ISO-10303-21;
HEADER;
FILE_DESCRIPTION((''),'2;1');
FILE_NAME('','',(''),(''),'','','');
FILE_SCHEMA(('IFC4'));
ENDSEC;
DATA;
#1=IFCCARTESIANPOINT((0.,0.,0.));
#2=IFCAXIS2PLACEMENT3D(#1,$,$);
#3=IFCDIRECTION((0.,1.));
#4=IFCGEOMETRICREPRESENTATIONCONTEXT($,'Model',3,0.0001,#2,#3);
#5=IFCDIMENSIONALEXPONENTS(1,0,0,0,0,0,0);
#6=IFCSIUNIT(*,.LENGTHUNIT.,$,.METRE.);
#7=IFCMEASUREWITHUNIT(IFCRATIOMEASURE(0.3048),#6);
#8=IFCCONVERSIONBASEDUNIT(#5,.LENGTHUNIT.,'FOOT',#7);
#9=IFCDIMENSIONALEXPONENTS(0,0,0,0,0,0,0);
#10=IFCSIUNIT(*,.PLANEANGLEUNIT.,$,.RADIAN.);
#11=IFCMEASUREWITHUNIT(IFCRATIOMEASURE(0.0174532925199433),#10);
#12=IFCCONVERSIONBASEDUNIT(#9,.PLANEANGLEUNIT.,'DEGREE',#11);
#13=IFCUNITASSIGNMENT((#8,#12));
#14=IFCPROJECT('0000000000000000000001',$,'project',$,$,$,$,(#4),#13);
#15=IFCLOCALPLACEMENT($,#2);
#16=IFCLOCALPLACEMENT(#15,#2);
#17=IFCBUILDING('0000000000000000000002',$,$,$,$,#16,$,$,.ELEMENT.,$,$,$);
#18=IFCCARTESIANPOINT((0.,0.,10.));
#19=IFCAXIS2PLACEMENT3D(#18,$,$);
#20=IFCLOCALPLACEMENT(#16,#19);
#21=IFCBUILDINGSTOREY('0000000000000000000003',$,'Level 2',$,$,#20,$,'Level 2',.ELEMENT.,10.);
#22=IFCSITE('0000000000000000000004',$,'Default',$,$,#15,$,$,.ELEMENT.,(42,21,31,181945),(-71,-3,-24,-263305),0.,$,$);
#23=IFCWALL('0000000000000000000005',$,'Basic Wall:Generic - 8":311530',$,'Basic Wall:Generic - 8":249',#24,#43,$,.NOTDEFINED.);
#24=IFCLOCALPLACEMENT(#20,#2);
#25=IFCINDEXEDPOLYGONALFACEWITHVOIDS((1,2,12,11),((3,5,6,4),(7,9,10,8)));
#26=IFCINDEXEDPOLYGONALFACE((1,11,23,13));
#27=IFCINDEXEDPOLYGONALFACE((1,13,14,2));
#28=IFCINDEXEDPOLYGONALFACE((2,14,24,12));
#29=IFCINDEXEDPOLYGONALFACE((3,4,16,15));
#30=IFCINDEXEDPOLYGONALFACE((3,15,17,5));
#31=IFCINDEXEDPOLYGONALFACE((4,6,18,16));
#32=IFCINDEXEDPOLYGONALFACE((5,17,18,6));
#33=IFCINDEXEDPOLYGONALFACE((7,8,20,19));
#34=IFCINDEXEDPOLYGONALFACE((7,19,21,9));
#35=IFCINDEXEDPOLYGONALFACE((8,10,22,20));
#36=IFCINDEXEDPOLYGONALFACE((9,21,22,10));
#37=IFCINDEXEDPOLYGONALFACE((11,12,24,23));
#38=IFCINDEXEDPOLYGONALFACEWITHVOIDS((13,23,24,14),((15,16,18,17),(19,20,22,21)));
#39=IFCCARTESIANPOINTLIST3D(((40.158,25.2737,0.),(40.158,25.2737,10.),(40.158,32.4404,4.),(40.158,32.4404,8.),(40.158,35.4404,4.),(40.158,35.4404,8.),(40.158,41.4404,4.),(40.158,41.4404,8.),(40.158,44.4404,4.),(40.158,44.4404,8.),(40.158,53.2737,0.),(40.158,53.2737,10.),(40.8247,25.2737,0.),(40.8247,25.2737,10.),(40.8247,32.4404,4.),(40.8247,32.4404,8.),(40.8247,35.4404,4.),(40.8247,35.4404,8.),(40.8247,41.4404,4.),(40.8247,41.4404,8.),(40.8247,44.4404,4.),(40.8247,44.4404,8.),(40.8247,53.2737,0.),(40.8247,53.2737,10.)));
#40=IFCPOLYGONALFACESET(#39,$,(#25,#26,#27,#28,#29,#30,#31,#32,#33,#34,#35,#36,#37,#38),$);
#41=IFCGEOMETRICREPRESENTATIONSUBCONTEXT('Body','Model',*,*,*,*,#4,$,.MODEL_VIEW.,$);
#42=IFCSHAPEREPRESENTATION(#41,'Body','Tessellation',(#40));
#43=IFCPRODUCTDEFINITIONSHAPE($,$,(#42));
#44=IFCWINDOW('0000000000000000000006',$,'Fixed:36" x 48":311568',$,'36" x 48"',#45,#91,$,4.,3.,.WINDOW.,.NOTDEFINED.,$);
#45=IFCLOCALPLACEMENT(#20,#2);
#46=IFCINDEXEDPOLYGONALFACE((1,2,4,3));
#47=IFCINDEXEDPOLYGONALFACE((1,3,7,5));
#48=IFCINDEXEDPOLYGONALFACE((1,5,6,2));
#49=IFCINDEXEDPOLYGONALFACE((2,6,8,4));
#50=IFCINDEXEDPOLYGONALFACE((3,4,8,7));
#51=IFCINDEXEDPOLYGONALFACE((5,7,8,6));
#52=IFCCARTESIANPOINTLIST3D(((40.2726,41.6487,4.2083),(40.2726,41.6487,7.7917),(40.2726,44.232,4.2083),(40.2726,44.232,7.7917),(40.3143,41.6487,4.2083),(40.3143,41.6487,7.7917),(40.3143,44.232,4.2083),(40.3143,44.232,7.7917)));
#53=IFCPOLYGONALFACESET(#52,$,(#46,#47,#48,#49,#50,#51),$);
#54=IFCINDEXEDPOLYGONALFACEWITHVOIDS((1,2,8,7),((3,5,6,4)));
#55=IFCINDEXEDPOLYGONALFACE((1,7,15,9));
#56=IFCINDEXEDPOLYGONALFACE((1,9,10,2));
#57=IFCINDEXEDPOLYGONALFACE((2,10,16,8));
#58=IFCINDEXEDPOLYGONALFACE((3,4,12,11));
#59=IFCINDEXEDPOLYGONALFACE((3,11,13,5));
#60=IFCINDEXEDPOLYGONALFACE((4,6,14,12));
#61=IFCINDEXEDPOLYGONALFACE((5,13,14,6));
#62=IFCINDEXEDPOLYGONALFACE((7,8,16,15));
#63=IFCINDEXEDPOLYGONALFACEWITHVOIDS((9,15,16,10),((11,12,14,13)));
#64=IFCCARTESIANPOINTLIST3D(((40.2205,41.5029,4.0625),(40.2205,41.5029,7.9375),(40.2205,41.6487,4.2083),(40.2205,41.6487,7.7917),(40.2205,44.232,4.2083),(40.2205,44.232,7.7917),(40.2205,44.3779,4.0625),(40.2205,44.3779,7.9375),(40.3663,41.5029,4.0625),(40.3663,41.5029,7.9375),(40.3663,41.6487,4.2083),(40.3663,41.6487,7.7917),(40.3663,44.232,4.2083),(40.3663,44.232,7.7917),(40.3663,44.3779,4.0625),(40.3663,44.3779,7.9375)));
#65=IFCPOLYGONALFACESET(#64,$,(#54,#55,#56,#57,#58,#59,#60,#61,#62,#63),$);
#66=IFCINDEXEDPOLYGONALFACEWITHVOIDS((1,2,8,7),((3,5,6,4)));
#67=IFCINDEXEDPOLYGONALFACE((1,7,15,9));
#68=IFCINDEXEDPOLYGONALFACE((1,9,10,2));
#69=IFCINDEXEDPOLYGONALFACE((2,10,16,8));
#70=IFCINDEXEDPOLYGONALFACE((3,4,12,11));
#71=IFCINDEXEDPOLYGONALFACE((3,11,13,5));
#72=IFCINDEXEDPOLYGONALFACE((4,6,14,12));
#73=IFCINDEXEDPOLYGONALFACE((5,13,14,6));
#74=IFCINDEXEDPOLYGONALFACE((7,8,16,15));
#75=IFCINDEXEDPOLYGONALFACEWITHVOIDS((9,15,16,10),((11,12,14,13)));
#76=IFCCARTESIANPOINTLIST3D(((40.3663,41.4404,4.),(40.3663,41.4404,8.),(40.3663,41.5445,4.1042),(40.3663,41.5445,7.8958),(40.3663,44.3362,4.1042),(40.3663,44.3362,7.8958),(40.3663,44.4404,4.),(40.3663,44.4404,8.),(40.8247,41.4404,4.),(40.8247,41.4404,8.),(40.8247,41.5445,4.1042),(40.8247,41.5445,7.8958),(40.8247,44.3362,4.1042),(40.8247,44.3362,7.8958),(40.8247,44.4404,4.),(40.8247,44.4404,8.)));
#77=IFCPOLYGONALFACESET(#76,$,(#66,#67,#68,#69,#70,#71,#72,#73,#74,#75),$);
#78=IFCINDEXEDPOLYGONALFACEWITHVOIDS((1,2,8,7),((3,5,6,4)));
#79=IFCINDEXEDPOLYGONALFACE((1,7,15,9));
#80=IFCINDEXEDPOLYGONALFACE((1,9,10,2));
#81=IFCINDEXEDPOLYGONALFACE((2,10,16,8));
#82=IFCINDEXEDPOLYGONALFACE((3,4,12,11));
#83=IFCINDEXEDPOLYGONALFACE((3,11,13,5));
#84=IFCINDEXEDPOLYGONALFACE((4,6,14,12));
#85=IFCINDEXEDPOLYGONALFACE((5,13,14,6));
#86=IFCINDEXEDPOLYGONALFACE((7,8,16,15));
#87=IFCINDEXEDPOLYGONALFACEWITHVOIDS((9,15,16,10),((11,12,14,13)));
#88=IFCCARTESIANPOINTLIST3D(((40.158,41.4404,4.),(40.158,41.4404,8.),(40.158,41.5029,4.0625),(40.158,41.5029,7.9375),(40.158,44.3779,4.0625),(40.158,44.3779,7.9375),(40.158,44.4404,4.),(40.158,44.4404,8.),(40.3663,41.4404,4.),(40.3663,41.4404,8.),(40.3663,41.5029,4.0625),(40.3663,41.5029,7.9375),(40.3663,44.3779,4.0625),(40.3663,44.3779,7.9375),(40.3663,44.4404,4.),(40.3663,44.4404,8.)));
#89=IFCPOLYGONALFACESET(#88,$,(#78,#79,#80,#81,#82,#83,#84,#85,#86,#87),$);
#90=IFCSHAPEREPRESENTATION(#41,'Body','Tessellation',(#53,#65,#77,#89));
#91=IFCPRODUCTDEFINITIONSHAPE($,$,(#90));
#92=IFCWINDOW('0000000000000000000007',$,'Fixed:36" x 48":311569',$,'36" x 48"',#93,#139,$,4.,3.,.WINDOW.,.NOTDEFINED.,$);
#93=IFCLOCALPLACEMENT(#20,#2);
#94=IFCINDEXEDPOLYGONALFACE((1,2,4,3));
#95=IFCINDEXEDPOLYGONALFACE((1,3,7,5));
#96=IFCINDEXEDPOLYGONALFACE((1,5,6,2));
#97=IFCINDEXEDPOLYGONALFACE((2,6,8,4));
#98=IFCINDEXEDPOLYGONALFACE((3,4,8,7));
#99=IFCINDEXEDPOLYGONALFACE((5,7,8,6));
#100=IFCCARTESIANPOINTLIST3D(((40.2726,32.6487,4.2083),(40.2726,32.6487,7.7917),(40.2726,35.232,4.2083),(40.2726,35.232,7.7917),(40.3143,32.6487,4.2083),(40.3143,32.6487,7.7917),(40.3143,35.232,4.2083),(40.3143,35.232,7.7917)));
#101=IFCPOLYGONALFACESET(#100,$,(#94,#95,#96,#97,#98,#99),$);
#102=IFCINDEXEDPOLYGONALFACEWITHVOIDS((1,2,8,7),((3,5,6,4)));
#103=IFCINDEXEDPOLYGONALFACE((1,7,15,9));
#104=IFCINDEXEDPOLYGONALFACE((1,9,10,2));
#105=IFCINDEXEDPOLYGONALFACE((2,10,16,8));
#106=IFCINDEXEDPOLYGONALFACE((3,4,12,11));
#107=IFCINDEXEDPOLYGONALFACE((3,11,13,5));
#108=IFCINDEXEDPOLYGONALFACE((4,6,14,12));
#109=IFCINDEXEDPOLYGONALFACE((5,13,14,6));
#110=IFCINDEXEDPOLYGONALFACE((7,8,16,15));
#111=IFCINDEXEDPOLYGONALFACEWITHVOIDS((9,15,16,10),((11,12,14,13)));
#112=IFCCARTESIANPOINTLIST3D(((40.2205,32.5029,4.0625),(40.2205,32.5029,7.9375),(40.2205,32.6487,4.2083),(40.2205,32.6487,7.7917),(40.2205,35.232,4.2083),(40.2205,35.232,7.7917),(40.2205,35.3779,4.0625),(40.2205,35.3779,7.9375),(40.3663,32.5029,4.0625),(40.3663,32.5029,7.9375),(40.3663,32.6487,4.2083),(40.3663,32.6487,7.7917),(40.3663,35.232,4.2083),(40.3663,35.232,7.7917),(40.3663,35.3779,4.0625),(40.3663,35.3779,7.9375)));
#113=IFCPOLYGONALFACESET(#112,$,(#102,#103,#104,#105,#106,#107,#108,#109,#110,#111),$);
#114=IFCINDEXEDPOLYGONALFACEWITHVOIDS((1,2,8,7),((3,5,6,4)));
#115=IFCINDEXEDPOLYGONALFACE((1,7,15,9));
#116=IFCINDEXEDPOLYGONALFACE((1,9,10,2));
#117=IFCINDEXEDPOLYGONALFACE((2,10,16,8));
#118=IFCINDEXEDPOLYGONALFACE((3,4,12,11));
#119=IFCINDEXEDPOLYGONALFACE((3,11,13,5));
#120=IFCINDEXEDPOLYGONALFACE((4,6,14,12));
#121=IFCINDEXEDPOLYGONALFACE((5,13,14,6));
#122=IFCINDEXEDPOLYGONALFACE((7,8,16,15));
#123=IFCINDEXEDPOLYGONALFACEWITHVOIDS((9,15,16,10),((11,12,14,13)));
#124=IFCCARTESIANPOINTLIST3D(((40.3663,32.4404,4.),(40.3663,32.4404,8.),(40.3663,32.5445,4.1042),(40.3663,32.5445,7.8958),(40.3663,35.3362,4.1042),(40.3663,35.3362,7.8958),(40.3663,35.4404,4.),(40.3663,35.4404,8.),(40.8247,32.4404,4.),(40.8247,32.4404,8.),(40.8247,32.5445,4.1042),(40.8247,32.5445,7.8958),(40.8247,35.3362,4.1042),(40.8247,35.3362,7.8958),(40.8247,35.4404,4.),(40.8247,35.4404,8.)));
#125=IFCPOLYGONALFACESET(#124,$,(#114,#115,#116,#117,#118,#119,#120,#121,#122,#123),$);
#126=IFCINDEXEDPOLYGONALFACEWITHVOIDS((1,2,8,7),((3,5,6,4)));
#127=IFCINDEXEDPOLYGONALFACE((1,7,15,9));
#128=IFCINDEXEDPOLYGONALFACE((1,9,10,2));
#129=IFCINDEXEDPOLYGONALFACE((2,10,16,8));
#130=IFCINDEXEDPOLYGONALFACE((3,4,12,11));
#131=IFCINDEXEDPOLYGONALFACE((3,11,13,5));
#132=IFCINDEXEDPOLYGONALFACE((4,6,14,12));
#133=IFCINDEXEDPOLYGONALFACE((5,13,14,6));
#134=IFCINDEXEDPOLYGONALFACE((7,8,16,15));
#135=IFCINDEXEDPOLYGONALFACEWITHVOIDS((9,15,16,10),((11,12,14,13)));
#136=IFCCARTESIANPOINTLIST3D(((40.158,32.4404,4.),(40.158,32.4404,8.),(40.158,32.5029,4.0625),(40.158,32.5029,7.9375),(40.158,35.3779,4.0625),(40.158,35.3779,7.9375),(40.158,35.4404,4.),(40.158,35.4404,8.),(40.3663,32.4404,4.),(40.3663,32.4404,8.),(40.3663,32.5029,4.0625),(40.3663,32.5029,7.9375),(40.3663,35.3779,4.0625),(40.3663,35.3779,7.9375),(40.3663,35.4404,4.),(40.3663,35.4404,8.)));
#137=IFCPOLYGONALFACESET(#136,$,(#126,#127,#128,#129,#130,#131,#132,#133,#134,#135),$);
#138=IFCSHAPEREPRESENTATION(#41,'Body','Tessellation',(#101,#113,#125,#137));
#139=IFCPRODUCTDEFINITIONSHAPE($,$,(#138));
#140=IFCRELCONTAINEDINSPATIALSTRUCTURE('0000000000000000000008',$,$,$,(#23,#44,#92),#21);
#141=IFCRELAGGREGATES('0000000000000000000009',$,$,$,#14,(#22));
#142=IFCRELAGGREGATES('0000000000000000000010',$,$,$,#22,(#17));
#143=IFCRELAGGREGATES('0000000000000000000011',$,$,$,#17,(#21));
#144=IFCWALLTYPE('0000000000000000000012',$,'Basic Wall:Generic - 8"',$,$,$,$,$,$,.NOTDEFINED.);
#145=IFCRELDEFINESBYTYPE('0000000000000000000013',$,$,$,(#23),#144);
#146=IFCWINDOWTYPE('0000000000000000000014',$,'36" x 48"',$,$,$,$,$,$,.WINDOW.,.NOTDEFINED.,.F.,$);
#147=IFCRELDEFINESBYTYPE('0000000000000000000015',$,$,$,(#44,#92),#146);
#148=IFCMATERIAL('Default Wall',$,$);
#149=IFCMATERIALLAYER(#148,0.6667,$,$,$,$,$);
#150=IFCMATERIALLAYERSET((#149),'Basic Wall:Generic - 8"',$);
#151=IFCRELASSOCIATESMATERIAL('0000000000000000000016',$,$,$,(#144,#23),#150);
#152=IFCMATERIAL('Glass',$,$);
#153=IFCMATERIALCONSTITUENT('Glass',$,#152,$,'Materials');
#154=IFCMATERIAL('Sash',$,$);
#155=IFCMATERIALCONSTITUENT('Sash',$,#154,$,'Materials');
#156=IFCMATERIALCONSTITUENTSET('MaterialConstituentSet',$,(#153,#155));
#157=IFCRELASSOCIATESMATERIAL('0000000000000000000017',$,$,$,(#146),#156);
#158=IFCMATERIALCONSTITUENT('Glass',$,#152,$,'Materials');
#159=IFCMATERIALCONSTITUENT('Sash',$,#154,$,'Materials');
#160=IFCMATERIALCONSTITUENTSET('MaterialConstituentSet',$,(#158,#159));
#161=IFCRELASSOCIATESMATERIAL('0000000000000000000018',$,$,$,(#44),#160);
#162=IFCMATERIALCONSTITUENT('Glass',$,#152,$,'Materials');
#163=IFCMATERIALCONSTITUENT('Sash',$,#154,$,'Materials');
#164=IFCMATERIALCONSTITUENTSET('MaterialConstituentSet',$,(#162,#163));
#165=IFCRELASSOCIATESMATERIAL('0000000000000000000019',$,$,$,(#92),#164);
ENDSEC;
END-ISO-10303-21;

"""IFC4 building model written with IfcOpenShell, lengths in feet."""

from ifc_helpers import new_model, entity, si_unit, converted_unit, direction, frame, frame_2d, origin, place, context, subcontext, project, spatial, polyline, rectangle, outline, extrude, source, transform, mapped, material, layer, layer_set, layer_usage, constituent, constituent_set, type_object, type_shapes, element, fill, save


model = new_model("IFC4")

# Units and contexts
model_context = context("Model", 3, precision=0.0001, world=origin(), true_north=direction((0.0, 1.0)))
body_context = subcontext(model_context, "Body", "Model", "MODEL_VIEW")
ifc_project = project(units=[converted_unit("LENGTHUNIT", "FOOT", entity("IfcRatioMeasure", 0.3048), si_unit("LENGTHUNIT", "METRE"), dimensions=[1, 0, 0, 0, 0, 0, 0]), converted_unit("PLANEANGLEUNIT", "DEGREE", entity("IfcRatioMeasure", 0.0174532925199433), si_unit("PLANEANGLEUNIT", "RADIAN"), dimensions=[0, 0, 0, 0, 0, 0, 0])], contexts=[model_context])

# Site, building, storey
site_placement = place(None, origin())
site = spatial("IfcSite", under=ifc_project, at=site_placement, Name="Default", CompositionType="ELEMENT", RefLatitude=(42, 21, 31, 181945), RefLongitude=(-71, -3, -24, -263305), RefElevation=0.0)
building_placement = place(site_placement, origin())
building = spatial("IfcBuilding", under=site, at=building_placement, CompositionType="ELEMENT")
storey_placement = place(building_placement, frame((0.0, 0.0, 10.0)))
storey = spatial("IfcBuildingStorey", under=building, at=storey_placement, Name="Level 2", LongName="Level 2", CompositionType="ELEMENT", Elevation=10.0)

# Wall, openings, windows
ifc_material_1 = material(Name="Default Wall")
ifc_layer_1 = layer(ifc_material_1, 0.6667)
ifc_layer_set_1 = layer_set([ifc_layer_1], Name="Basic Wall:Generic - 8\"")
wall_type = type_object("IfcWallType", Name="Basic Wall:Generic - 8\"", PredefinedType="NOTDEFINED", material=ifc_layer_set_1)
ifc_material_2 = material(Name="Glass")
ifc_material_3 = material(Name="Sash")
ifc_layer_usage_1 = layer_usage(ifc_layer_set_1, "AXIS2", "NEGATIVE", 0.3333)
wall_1_placement = place(storey_placement, frame((40.4913, 53.2737, 0.0), z_axis=(0.0, 0.0, 1.0), x_axis=(0.0, -1.0, 0.0)))
wall_1 = element("IfcWall", 1, at=wall_1_placement, inside=storey, type_object=wall_type, material=ifc_layer_usage_1, Name="Basic Wall:Generic - 8\":311530", ObjectType="Basic Wall:Generic - 8\":249", PredefinedType="NOTDEFINED", context=body_context, shape_type="SweptSolid", body=[
    extrude(rectangle(XDim=28.0, YDim=0.6667, at=frame_2d((14.0, 0.0), x_axis=(-1.0, 0.0))), origin(), (0.0, 0.0, 1.0), 10.0),
])
opening_1_placement = place(wall_1_placement, frame((11.8333, 0.3333, 4.0)))
opening_1 = element("IfcOpeningElement", 2, at=opening_1_placement, cuts=wall_1, ObjectType="Opening", PredefinedType="OPENING", context=body_context, shape_type="SweptSolid", body=[
    extrude(rectangle(XDim=4.0, YDim=3.0, at=frame_2d((2.0, 1.5), x_axis=(-1.0, 0.0))), frame((0.0, 0.0, 0.0), z_axis=(0.0, -1.0, 0.0), x_axis=(0.0, 0.0, 1.0)), (0.0, 0.0, 1.0), 0.6667),
])
opening_2_placement = place(wall_1_placement, frame((20.8333, 0.3333, 4.0)))
opening_2 = element("IfcOpeningElement", 3, at=opening_2_placement, cuts=wall_1, ObjectType="Opening", PredefinedType="OPENING", context=body_context, shape_type="SweptSolid", body=[
    extrude(rectangle(XDim=4.0, YDim=3.0, at=frame_2d((2.0, 1.5), x_axis=(-1.0, 0.0))), frame((0.0, 0.0, 0.0), z_axis=(0.0, -1.0, 0.0), x_axis=(0.0, 0.0, 1.0)), (0.0, 0.0, 1.0), 0.6667),
])
ifc_constituent_1 = constituent(ifc_material_2, Name="Glass", Category="Materials")
ifc_constituent_2 = constituent(ifc_material_3, Name="Sash", Category="Materials")
ifc_constituent_set_1 = constituent_set(constituents=[ifc_constituent_1, ifc_constituent_2], Name="MaterialConstituentSet")
ifc_constituent_3 = constituent(ifc_material_2, Name="Glass", Category="Materials")
ifc_constituent_4 = constituent(ifc_material_3, Name="Sash", Category="Materials")
ifc_constituent_set_2 = constituent_set(constituents=[ifc_constituent_3, ifc_constituent_4], Name="MaterialConstituentSet")
window_type_1 = type_object("IfcWindowType", Name="36\" x 48\"", ParameterTakesPrecedence=False, PartitioningType="NOTDEFINED", PredefinedType="WINDOW", material=ifc_constituent_set_2)
shared_shape_1 = source(origin(), body_context, "Body", "SweptSolid", [
    extrude(rectangle(XDim=0.0417, YDim=2.5833, at=frame_2d((0.0, 0.0), x_axis=(1.0, 0.0))), frame((1.5, 0.5312, 0.2083), z_axis=(0.0, 0.0, 1.0), x_axis=(0.0, 1.0, 0.0)), (0.0, 0.0, 1.0), 3.5833),
    extrude(outline(polyline([(-1.4375, -1.9375), (1.4375, -1.9375), (1.4375, 1.9375), (-1.4375, 1.9375), (-1.4375, -1.9375)]), holes=[polyline([(-1.2917, -1.7917), (-1.2917, 1.7917), (1.2917, 1.7917), (1.2917, -1.7917), (-1.2917, -1.7917)])]), frame((1.5, 0.4583, 2.0), z_axis=(0.0, 1.0, 0.0), x_axis=(1.0, 0.0, 0.0)), (0.0, 0.0, 1.0), 0.1458),
    extrude(outline(polyline([(-1.5, -2.0), (1.5, -2.0), (1.5, 2.0), (-1.5, 2.0), (-1.5, -2.0)]), holes=[polyline([(-1.3958, -1.8958), (-1.3958, 1.8958), (1.3958, 1.8958), (1.3958, -1.8958), (-1.3958, -1.8958)])]), frame((1.5, 0.0, 2.0), z_axis=(0.0, 1.0, 0.0), x_axis=(1.0, 0.0, 0.0)), (0.0, 0.0, 1.0), 0.4583),
    extrude(outline(polyline([(-2.0, -1.5), (2.0, -1.5), (2.0, 1.5), (-2.0, 1.5), (-2.0, -1.5)]), holes=[polyline([(-1.9375, -1.4375), (-1.9375, 1.4375), (1.9375, 1.4375), (1.9375, -1.4375), (-1.9375, -1.4375)])]), frame((1.5, 0.4583, 2.0), z_axis=(0.0, 1.0, 0.0), x_axis=(0.0, 0.0, -1.0)), (0.0, 0.0, 1.0), 0.2083),
])
type_shapes(window_type_1, [shared_shape_1])
window_1_placement = place(opening_1_placement, frame((0.0, 0.0, 0.0), z_axis=(0.0, 0.0, 1.0), x_axis=(-1.0, 0.0, 0.0)))
window_1 = element("IfcWindow", 4, at=window_1_placement, inside=storey, type_object=window_type_1, material=ifc_constituent_set_1, Name="Fixed:36\" x 48\":311568", ObjectType="36\" x 48\"", OverallHeight=4.0, OverallWidth=3.0, PartitioningType="NOTDEFINED", PredefinedType="WINDOW", context=body_context, shape_type="MappedRepresentation", body=[
    mapped(shared_shape_1, transform((0.0, 0.0, 0.0), scale=1.0)),
])
fill(opening_1, window_1)
ifc_constituent_5 = constituent(ifc_material_2, Name="Glass", Category="Materials")
ifc_constituent_6 = constituent(ifc_material_3, Name="Sash", Category="Materials")
ifc_constituent_set_3 = constituent_set(constituents=[ifc_constituent_5, ifc_constituent_6], Name="MaterialConstituentSet")
window_2_placement = place(opening_2_placement, frame((0.0, 0.0, 0.0), z_axis=(0.0, 0.0, 1.0), x_axis=(-1.0, 0.0, 0.0)))
window_2 = element("IfcWindow", 5, at=window_2_placement, inside=storey, type_object=window_type_1, material=ifc_constituent_set_3, Name="Fixed:36\" x 48\":311569", ObjectType="36\" x 48\"", OverallHeight=4.0, OverallWidth=3.0, PartitioningType="NOTDEFINED", PredefinedType="WINDOW", context=body_context, shape_type="MappedRepresentation", body=[
    mapped(shared_shape_1, transform((0.0, 0.0, 0.0), scale=1.0)),
])
fill(opening_2, window_2)

save(model, "model.ifc")
